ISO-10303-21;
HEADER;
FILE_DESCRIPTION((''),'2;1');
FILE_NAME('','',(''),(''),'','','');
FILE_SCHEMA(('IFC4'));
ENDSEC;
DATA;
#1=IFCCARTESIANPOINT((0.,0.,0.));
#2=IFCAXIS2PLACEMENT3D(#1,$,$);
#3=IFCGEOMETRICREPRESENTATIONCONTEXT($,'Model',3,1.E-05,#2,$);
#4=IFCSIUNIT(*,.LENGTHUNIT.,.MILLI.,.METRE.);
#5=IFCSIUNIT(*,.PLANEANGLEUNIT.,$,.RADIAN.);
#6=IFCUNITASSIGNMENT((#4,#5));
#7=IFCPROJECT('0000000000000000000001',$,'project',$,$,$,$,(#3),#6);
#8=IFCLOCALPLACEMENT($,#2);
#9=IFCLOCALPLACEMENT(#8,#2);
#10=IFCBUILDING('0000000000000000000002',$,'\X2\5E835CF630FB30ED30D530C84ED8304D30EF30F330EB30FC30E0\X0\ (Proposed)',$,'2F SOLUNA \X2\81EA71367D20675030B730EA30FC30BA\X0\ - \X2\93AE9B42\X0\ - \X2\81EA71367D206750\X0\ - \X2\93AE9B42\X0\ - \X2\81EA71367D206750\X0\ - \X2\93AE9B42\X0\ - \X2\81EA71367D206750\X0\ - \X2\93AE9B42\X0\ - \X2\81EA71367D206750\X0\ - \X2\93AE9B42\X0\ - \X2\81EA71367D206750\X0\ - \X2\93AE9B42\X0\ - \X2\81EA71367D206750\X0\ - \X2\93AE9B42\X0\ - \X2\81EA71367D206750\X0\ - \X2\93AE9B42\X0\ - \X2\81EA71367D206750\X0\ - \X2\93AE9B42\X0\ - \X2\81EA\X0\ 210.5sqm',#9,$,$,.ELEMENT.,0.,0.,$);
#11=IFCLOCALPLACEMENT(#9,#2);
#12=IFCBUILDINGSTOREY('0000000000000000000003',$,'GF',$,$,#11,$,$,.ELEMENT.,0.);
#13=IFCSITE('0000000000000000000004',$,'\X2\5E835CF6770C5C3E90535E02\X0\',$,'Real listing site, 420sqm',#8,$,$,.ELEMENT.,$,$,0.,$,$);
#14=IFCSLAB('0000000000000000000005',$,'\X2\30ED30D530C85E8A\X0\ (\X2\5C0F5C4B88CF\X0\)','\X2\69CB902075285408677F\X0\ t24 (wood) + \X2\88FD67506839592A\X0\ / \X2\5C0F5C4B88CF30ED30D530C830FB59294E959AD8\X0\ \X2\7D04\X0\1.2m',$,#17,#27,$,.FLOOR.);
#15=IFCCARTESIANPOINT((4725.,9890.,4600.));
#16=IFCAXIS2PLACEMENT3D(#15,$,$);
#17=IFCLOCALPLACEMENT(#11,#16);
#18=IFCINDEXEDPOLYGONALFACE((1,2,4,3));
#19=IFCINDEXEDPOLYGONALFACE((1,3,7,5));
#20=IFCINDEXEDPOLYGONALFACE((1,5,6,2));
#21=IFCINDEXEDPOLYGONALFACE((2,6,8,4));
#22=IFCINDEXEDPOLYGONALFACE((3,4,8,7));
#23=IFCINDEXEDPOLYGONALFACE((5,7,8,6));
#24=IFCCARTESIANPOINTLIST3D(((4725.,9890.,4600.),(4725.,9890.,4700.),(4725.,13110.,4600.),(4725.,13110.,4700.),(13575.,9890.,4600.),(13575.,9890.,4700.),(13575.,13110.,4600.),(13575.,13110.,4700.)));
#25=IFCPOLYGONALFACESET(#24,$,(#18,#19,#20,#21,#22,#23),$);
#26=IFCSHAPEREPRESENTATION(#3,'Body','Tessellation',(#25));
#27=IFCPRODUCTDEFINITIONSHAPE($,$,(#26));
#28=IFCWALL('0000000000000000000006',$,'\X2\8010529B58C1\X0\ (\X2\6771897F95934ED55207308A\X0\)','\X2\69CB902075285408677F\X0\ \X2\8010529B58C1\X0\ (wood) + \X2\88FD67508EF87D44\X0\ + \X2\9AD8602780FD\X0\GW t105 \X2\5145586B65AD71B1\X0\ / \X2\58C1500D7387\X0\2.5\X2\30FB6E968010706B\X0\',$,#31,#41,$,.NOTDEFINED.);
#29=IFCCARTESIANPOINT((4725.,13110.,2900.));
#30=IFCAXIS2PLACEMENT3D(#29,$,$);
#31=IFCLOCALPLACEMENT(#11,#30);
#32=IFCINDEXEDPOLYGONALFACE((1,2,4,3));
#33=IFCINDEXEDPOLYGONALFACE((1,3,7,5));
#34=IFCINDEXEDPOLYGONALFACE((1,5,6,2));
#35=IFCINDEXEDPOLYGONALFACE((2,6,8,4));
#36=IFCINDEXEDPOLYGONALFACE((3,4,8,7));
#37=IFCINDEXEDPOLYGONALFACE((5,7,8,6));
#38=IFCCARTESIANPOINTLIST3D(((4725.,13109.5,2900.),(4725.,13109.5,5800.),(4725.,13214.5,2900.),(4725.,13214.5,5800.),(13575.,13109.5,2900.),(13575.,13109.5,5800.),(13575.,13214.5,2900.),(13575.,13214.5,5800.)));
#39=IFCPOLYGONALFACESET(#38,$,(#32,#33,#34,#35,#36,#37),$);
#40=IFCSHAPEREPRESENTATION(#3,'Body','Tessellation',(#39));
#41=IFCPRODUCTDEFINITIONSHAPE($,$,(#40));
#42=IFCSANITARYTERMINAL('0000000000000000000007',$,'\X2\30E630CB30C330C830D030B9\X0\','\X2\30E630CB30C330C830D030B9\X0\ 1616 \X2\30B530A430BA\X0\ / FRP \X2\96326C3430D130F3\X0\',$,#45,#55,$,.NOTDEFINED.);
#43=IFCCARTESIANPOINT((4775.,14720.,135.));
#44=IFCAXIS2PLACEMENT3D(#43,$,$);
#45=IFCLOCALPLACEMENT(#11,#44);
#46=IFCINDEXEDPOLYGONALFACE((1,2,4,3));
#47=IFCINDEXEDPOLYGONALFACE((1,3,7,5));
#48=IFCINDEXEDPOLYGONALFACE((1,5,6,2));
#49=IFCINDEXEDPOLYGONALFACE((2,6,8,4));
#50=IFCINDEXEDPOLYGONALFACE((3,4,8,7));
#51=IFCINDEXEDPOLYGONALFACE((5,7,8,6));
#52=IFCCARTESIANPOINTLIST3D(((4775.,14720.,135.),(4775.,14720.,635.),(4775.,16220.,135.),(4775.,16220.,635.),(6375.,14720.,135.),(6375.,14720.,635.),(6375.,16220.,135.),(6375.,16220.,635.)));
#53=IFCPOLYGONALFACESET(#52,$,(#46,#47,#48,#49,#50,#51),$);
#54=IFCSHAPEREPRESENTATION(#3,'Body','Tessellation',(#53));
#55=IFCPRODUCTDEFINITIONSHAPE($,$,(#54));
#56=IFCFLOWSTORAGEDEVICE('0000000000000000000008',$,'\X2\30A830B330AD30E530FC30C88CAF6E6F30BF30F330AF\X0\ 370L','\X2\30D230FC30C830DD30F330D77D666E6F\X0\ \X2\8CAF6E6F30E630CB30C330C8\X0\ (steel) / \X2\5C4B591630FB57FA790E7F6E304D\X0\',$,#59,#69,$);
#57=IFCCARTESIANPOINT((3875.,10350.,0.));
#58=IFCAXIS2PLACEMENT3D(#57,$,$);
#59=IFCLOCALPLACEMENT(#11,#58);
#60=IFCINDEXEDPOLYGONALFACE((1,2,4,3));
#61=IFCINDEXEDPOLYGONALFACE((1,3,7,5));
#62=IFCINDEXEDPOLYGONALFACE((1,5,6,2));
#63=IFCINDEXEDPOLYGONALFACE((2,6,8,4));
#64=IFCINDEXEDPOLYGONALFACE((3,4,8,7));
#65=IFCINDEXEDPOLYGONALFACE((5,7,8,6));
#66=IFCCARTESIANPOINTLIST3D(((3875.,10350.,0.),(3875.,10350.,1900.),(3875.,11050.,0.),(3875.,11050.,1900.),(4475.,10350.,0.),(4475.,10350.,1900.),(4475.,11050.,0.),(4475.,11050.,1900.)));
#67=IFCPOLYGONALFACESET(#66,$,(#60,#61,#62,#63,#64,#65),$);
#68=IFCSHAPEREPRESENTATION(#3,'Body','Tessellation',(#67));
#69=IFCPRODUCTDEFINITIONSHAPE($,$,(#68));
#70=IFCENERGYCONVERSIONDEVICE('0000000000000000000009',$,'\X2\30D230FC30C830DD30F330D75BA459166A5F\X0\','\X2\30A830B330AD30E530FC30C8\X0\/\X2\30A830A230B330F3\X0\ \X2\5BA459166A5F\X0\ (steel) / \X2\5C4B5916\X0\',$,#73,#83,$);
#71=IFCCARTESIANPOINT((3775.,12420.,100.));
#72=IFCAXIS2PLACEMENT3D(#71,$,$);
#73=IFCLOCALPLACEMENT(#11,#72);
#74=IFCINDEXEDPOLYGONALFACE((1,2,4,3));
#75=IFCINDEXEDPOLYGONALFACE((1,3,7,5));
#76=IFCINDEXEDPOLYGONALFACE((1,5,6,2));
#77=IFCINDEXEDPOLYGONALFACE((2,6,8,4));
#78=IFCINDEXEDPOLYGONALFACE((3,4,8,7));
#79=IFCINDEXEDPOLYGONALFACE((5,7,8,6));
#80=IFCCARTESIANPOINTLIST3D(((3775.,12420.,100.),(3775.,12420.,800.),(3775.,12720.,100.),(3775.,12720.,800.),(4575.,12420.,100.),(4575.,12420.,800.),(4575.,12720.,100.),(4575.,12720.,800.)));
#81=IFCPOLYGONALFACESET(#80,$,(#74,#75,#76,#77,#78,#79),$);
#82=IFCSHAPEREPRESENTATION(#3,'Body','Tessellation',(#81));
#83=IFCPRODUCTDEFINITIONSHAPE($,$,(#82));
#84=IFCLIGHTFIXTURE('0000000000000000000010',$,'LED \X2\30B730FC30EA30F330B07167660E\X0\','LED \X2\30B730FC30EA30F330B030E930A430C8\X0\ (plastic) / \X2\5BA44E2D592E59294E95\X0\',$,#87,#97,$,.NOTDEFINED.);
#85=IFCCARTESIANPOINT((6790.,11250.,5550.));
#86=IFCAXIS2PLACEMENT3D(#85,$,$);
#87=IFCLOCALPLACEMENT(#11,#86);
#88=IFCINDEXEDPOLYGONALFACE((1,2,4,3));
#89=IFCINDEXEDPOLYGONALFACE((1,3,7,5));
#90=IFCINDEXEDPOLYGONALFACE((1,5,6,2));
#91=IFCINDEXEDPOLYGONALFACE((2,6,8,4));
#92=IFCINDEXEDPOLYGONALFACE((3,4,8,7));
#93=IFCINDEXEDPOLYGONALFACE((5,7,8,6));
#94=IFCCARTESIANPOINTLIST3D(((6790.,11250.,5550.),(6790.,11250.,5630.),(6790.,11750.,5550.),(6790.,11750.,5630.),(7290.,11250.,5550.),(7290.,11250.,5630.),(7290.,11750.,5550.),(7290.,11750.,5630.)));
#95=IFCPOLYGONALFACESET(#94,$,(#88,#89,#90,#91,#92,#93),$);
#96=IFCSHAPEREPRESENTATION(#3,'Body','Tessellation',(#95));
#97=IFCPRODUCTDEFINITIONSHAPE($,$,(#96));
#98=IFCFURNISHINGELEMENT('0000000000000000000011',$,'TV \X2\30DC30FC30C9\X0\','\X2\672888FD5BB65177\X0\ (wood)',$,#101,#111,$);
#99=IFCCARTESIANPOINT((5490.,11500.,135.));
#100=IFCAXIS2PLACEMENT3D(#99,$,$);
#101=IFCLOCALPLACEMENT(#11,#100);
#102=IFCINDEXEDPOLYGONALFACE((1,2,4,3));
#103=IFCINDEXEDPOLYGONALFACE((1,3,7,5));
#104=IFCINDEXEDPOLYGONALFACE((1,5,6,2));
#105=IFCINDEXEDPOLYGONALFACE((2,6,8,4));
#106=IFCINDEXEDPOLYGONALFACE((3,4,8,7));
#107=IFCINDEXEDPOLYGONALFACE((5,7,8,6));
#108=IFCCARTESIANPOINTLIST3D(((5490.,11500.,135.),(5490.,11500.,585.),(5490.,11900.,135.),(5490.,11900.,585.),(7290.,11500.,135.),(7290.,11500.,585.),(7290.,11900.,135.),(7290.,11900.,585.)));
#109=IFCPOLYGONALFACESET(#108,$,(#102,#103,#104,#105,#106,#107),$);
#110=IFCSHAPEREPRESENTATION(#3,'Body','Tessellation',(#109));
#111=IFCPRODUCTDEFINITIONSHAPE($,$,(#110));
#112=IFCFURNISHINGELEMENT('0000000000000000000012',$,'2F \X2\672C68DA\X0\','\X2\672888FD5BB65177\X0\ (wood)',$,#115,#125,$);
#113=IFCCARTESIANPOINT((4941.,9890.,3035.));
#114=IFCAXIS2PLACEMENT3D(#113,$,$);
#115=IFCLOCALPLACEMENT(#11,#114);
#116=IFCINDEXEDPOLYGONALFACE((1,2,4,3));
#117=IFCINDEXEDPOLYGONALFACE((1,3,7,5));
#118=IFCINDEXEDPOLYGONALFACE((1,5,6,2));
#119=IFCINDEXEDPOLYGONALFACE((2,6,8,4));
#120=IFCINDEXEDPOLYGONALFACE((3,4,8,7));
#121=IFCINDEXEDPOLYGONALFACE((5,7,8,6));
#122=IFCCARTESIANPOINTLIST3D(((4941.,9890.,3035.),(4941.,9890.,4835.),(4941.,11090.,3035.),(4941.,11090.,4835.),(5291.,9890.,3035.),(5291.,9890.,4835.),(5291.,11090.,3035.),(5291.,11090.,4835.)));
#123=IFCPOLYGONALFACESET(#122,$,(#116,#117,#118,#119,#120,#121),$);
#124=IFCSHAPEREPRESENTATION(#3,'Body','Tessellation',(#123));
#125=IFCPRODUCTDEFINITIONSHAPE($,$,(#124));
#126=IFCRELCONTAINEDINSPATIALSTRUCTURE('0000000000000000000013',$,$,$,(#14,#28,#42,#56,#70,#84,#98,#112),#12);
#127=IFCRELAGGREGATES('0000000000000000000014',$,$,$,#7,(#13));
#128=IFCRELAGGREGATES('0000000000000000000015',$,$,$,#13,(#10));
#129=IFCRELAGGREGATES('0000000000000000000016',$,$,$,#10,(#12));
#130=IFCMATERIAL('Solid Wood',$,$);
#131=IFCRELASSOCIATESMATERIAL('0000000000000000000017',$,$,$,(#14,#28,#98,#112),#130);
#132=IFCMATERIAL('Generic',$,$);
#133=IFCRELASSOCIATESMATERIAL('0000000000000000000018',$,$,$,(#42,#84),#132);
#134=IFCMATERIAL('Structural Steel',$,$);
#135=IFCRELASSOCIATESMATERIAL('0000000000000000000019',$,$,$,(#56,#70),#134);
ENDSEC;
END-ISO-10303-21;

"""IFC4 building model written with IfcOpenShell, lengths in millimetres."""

from ifc_helpers import new_model, si_unit, frame, frame_2d, origin, place, context, project, spatial, rectangle, extrude, material, element, save


model = new_model("IFC4")

# Units and contexts
model_context = context("Model", 3, precision=1e-05, world=origin())
ifc_project = project(units=[si_unit("LENGTHUNIT", "METRE", prefix="MILLI"), si_unit("PLANEANGLEUNIT", "RADIAN")], contexts=[model_context])

# Site, building, storey
site_placement = place(None, origin())
site = spatial("IfcSite", under=ifc_project, at=site_placement, Name="広島県尾道市", ObjectType="Real listing site, 420sqm", CompositionType="ELEMENT", RefElevation=0.0)
building_placement = place(site_placement, origin())
building = spatial("IfcBuilding", under=site, at=building_placement, Name="広島・ロフト付きワンルーム (Proposed)", ObjectType="2F SOLUNA 自然素材シリーズ - 鎮魂 - 自然素材 - 鎮魂 - 自然素材 - 鎮魂 - 自然素材 - 鎮魂 - 自然素材 - 鎮魂 - 自然素材 - 鎮魂 - 自然素材 - 鎮魂 - 自然素材 - 鎮魂 - 自然素材 - 鎮魂 - 自 210.5sqm", CompositionType="ELEMENT", ElevationOfRefHeight=0.0, ElevationOfTerrain=0.0)
storey_placement = place(building_placement, origin())
storey = spatial("IfcBuildingStorey", under=building, at=storey_placement, Name="GF", CompositionType="ELEMENT", Elevation=0.0)

# Shared definitions
ifc_material_1 = material(Name="Solid Wood")

# Slab
slab_placement = place(storey_placement, frame((4725.0, 9890.0, 4600.0)))
element("IfcSlab", 1, at=slab_placement, inside=storey, material=ifc_material_1, Name="ロフト床 (小屋裏)", Description="構造用合板 t24 (wood) + 製材根太 / 小屋裏ロフト・天井高 約1.2m", PredefinedType="FLOOR", context=model_context, shape_type="SweptSolid", body=[
    extrude(rectangle(XDim=8850.0, YDim=3220.0, at=frame_2d((4425.0, 1610.0))), frame((4725.0, 9890.0, 4600.0)), (0.0, 0.0, 1.0), 100.0),
])

# Wall
wall_1_placement = place(storey_placement, frame((4725.0, 13110.0, 2900.0)))
element("IfcWall", 2, at=wall_1_placement, inside=storey, material=ifc_material_1, Name="耐力壁 (東西間仕切り)", Description="構造用合板 耐力壁 (wood) + 製材軸組 + 高性能GW t105 充填断熱 / 壁倍率2.5・準耐火", PredefinedType="NOTDEFINED", context=model_context, shape_type="SweptSolid", body=[
    extrude(rectangle(XDim=8850.0, YDim=105.0, at=frame_2d((4425.0, 52.0))), frame((4725.0, 13110.0, 2900.0)), (0.0, 0.0, 1.0), 2900.0),
])

# Sanitary terminal
ifc_material_2 = material(Name="Generic")
sanitary_terminal_placement = place(storey_placement, frame((4775.0, 14720.0, 135.0)))
element("IfcSanitaryTerminal", 3, at=sanitary_terminal_placement, inside=storey, material=ifc_material_2, Name="ユニットバス", Description="ユニットバス 1616 サイズ / FRP 防水パン", PredefinedType="NOTDEFINED", context=model_context, shape_type="SweptSolid", body=[
    extrude(rectangle(XDim=1600.0, YDim=1500.0, at=frame_2d((800.0, 750.0))), frame((4775.0, 14720.0, 135.0)), (0.0, 0.0, 1.0), 500.0),
])

# Flow storage device
ifc_material_3 = material(Name="Structural Steel")
flow_storage_device_placement = place(storey_placement, frame((3875.0, 10350.0, 0.0)))
element("IfcFlowStorageDevice", 4, at=flow_storage_device_placement, inside=storey, material=ifc_material_3, Name="エコキュート貯湯タンク 370L", Description="ヒートポンプ給湯 貯湯ユニット (steel) / 屋外・基礎置き", context=model_context, shape_type="SweptSolid", body=[
    extrude(rectangle(XDim=600.0, YDim=700.0, at=frame_2d((300.0, 350.0))), frame((3875.0, 10350.0, 0.0)), (0.0, 0.0, 1.0), 1900.0),
])

# Energy conversion device
energy_conversion_device_placement = place(storey_placement, frame((3775.0, 12420.0, 100.0)))
element("IfcEnergyConversionDevice", 5, at=energy_conversion_device_placement, inside=storey, material=ifc_material_3, Name="ヒートポンプ室外機", Description="エコキュート/エアコン 室外機 (steel) / 屋外", context=model_context, shape_type="SweptSolid", body=[
    extrude(rectangle(XDim=800.0, YDim=300.0, at=frame_2d((400.0, 150.0))), frame((3775.0, 12420.0, 100.0)), (0.0, 0.0, 1.0), 700.0),
])

# Light fixture
light_fixture_placement = place(storey_placement, frame((6790.0, 11250.0, 5550.0)))
element("IfcLightFixture", 6, at=light_fixture_placement, inside=storey, material=ifc_material_2, Name="LED シーリング照明", Description="LED シーリングライト (plastic) / 室中央天井", PredefinedType="NOTDEFINED", context=model_context, shape_type="SweptSolid", body=[
    extrude(rectangle(XDim=500.0, YDim=500.0, at=frame_2d((250.0, 250.0))), frame((6790.0, 11250.0, 5550.0)), (0.0, 0.0, 1.0), 80.0),
])

# Furnishing elements
furnishing_1_placement = place(storey_placement, frame((5490.0, 11500.0, 135.0)))
element("IfcFurnishingElement", 7, at=furnishing_1_placement, inside=storey, material=ifc_material_1, Name="TV ボード", Description="木製家具 (wood)", context=model_context, shape_type="SweptSolid", body=[
    extrude(rectangle(XDim=1800.0, YDim=400.0, at=frame_2d((900.0, 200.0))), frame((5490.0, 11500.0, 135.0)), (0.0, 0.0, 1.0), 450.0),
])
furnishing_2_placement = place(storey_placement, frame((4941.0, 9890.0, 3035.0)))
element("IfcFurnishingElement", 8, at=furnishing_2_placement, inside=storey, material=ifc_material_1, Name="2F 本棚", Description="木製家具 (wood)", context=model_context, shape_type="SweptSolid", body=[
    extrude(rectangle(XDim=350.0, YDim=1200.0, at=frame_2d((175.0, 600.0))), frame((4941.0, 9890.0, 3035.0)), (0.0, 0.0, 1.0), 1800.0),
])

save(model, "model.ifc")
